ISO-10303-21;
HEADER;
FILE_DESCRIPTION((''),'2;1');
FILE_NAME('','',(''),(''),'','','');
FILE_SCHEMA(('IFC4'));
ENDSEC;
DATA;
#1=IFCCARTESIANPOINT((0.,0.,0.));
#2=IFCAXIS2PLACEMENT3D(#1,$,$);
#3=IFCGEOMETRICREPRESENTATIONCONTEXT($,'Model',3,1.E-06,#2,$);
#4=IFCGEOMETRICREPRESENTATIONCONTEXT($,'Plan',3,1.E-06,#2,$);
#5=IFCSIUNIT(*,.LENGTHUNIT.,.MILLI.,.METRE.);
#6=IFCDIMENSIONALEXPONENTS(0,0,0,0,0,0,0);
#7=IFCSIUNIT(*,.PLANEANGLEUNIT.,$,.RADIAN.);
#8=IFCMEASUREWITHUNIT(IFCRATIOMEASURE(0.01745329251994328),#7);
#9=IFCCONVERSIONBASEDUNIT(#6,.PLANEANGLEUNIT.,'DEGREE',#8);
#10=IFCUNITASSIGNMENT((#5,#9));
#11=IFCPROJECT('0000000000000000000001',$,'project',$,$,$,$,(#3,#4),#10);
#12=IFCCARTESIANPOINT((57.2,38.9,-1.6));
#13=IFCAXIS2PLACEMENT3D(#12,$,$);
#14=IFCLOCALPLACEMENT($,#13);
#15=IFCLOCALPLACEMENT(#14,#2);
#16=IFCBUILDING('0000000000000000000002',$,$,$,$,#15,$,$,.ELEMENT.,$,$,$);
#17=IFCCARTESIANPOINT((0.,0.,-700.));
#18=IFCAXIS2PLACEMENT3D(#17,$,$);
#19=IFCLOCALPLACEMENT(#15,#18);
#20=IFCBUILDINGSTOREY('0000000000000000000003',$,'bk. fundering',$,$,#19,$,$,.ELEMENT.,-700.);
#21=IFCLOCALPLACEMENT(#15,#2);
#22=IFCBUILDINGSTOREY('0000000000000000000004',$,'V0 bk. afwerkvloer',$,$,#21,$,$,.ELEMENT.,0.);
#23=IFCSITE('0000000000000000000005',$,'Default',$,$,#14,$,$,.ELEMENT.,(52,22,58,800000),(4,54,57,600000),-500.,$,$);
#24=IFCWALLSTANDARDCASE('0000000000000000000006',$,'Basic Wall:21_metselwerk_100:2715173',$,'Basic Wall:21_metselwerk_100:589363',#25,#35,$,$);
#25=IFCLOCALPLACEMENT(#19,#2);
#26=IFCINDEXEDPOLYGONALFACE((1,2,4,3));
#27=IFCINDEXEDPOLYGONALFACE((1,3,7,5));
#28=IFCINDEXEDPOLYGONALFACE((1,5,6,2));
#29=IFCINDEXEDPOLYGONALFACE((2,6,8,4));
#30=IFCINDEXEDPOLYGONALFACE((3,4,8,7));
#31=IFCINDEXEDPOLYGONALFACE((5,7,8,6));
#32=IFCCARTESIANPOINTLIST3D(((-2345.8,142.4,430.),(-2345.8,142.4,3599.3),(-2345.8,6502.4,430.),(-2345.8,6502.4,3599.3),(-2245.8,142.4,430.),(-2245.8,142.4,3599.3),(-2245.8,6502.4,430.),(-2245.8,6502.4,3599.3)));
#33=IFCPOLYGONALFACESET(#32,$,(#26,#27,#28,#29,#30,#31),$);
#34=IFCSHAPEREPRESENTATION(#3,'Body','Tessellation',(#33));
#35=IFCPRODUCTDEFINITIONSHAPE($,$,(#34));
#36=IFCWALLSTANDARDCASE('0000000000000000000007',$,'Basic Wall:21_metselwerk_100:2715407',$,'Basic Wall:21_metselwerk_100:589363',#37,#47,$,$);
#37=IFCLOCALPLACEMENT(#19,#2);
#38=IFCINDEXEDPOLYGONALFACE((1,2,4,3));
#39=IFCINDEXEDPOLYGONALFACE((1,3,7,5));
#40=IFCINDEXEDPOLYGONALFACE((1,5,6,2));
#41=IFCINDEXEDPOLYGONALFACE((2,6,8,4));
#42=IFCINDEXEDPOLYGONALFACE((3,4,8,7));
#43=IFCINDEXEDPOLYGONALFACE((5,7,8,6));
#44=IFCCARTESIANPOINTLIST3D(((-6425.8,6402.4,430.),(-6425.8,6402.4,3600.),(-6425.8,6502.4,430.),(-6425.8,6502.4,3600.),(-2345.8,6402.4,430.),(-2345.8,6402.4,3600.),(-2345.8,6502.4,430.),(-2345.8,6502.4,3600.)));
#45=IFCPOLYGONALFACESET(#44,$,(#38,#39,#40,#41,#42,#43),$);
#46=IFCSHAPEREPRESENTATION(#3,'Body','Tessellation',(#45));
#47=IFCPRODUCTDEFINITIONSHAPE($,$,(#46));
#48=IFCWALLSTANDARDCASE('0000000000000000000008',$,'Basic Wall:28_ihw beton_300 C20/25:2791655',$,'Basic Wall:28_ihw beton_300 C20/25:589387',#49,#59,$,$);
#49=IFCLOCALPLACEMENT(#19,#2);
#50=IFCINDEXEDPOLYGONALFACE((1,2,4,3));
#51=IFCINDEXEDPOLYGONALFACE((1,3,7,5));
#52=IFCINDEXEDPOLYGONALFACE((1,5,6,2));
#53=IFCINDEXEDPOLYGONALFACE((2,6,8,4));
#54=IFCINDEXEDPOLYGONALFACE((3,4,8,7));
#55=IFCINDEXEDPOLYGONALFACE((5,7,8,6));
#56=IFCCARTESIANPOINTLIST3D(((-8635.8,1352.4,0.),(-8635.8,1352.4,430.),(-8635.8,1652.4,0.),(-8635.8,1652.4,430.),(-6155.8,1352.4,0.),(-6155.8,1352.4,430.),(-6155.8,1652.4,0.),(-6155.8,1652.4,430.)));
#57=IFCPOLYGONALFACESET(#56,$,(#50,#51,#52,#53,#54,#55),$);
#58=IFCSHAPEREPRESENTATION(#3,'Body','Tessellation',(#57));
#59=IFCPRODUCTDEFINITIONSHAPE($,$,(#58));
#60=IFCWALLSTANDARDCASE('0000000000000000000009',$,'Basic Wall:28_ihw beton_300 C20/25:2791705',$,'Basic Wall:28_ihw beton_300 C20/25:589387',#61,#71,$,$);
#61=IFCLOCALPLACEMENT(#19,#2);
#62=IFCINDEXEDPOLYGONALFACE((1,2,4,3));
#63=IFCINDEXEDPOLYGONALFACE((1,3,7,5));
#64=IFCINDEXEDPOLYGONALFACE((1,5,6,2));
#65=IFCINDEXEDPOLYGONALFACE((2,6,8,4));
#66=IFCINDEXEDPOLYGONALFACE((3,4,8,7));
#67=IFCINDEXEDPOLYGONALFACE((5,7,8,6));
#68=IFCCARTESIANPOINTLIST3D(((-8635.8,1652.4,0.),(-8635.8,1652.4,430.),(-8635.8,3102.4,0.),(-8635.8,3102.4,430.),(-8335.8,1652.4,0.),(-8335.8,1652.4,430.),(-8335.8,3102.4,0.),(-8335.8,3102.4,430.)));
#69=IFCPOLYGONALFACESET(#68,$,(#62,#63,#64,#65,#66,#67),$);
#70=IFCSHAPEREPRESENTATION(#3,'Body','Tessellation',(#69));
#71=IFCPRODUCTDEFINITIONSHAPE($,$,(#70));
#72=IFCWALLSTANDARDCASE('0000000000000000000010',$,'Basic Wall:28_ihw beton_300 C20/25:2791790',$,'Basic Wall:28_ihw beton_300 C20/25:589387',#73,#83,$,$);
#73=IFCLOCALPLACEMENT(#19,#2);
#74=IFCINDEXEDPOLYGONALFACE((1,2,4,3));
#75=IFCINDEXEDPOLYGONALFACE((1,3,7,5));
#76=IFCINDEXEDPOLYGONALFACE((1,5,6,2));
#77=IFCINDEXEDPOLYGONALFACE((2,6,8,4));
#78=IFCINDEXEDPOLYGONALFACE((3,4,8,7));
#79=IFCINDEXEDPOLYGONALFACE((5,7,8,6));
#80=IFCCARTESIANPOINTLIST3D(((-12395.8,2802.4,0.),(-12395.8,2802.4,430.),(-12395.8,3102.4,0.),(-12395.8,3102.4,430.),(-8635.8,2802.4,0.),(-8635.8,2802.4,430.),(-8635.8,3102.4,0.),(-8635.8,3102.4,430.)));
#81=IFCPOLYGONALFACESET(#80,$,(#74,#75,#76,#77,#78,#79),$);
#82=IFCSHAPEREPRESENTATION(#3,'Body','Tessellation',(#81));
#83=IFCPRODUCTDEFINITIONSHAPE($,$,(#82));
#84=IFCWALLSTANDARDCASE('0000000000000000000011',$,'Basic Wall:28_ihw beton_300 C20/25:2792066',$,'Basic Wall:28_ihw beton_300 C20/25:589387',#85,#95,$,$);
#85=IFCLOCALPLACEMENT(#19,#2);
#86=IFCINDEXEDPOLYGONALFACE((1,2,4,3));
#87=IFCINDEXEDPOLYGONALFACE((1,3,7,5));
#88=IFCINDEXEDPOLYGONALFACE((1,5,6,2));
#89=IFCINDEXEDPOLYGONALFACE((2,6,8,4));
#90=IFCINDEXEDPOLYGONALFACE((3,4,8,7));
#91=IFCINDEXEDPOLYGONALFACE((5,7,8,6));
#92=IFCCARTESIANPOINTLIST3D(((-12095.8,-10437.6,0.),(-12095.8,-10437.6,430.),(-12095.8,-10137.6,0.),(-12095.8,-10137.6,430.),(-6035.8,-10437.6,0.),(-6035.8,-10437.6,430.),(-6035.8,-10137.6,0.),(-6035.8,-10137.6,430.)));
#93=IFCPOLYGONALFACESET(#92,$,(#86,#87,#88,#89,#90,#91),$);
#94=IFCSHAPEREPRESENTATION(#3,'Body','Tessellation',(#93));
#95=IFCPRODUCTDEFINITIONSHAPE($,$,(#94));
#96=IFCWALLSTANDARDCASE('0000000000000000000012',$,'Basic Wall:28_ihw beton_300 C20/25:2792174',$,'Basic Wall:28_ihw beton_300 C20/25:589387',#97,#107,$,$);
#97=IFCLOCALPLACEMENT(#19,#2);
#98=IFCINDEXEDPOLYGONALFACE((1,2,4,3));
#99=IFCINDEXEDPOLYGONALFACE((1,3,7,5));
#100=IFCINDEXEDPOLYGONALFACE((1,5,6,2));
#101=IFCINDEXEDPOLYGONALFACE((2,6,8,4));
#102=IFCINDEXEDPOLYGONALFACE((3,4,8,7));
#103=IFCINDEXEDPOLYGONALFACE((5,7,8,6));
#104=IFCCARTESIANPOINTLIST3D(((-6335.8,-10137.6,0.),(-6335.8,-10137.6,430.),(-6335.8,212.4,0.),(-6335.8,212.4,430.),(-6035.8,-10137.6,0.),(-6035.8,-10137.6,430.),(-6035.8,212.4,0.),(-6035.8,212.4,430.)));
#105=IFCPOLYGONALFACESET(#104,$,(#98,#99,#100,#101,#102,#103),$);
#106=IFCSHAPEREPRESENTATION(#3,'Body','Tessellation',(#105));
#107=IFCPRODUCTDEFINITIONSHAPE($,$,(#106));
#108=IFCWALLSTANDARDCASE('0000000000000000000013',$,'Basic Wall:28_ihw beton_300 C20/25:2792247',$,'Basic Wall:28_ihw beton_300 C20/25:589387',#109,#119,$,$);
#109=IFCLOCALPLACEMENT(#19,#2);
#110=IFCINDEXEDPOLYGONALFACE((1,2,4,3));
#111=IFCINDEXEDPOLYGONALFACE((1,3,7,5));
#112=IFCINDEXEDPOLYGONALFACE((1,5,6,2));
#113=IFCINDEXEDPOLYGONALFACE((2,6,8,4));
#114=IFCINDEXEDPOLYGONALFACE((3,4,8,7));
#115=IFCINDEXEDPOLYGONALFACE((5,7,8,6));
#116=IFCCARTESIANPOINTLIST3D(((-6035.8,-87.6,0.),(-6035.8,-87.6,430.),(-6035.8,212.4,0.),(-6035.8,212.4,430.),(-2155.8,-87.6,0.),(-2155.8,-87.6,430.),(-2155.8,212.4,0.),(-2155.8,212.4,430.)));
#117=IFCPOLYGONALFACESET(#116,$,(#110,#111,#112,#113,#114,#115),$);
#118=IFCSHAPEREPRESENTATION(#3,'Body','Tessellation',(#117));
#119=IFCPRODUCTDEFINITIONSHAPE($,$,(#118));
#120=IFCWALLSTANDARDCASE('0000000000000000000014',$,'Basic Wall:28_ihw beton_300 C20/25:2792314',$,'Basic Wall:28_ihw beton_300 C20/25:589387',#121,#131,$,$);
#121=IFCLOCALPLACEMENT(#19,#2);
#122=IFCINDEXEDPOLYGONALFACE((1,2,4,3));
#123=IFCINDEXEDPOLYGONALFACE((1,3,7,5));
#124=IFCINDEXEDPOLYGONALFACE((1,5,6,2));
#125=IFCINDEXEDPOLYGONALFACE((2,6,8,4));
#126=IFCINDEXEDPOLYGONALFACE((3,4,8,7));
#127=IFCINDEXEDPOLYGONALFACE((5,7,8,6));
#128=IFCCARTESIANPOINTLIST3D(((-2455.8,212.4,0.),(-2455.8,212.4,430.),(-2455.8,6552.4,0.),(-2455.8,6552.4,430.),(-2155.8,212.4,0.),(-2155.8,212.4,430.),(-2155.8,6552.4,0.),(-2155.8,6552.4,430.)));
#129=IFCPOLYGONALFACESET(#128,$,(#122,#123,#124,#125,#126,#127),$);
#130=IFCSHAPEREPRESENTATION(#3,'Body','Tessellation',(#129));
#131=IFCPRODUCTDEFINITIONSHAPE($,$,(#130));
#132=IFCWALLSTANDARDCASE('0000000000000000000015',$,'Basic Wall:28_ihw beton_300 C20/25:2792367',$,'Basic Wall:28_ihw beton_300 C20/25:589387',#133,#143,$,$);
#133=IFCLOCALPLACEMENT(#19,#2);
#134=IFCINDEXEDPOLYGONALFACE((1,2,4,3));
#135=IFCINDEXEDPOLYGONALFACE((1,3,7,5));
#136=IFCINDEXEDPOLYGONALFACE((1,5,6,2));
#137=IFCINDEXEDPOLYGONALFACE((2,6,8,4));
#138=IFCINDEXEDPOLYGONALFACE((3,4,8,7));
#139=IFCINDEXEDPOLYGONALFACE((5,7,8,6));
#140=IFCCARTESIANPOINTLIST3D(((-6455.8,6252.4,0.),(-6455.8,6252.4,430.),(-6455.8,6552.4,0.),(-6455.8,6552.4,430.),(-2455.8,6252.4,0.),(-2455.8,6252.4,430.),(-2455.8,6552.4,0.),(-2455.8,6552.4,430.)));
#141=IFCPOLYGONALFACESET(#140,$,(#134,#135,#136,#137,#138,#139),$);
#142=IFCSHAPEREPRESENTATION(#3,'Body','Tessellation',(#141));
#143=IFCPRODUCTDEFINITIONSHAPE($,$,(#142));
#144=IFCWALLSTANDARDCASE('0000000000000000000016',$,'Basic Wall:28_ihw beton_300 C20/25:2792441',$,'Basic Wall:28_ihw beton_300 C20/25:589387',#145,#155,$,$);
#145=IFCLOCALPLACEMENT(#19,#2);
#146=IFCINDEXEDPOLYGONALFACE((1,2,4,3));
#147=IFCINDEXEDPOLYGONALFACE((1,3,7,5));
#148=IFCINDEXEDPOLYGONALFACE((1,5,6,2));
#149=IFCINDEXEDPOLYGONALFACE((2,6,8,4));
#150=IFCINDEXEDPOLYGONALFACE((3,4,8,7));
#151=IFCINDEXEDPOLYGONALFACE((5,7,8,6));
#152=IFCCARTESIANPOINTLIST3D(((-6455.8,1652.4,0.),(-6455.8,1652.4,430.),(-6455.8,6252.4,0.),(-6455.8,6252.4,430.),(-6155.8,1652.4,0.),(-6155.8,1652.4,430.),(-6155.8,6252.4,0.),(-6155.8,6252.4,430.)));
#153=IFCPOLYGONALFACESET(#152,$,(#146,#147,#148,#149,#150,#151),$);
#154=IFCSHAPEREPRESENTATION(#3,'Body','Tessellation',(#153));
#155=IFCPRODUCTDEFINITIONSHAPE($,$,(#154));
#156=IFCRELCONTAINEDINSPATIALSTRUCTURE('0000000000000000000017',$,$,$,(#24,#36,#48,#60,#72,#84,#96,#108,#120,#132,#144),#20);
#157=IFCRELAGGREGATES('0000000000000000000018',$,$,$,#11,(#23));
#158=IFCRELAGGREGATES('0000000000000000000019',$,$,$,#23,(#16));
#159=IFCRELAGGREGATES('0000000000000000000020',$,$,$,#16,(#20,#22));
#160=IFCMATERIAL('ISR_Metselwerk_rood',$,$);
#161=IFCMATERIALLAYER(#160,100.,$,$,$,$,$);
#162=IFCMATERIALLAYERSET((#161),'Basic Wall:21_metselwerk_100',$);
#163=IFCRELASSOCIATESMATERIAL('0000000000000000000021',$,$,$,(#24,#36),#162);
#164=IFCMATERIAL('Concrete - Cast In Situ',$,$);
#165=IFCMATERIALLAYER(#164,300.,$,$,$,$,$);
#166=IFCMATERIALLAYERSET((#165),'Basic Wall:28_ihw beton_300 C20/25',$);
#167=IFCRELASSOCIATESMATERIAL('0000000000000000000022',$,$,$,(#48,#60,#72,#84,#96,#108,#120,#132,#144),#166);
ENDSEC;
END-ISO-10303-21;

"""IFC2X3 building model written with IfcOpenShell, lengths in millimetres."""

from ifc_helpers import new_model, entity, si_unit, converted_unit, frame, frame_2d, origin, place, context, project, spatial, rectangle, extrude, material, layer, layer_set, layer_usage, element, save


model = new_model("IFC2X3")

# Units and contexts
model_context = context("Model", 3, precision=1e-06, world=origin())
plan_context = context("Plan", 3, precision=1e-06, world=origin())
ifc_project = project(units=[si_unit("LENGTHUNIT", "METRE", prefix="MILLI"), converted_unit("PLANEANGLEUNIT", "DEGREE", entity("IfcRatioMeasure", 0.01745329251994328), si_unit("PLANEANGLEUNIT", "RADIAN"), dimensions=[0, 0, 0, 0, 0, 0, 0])], contexts=[model_context, plan_context])

# Site, building, storey
site_placement = place(None, frame((57.2, 38.9, -1.6)))
site = spatial("IfcSite", under=ifc_project, at=site_placement, Name="Default", CompositionType="ELEMENT", RefLatitude=(52, 22, 58, 800000), RefLongitude=(4, 54, 57, 600000), RefElevation=-500.0)
building_placement = place(site_placement, origin())
building = spatial("IfcBuilding", under=site, at=building_placement, CompositionType="ELEMENT")
storey_1_placement = place(building_placement, frame((0.0, 0.0, -700.0)))
storey_1 = spatial("IfcBuildingStorey", under=building, at=storey_1_placement, Name="bk. fundering", CompositionType="ELEMENT", Elevation=-700.0)

# Shared definitions
ifc_material_1 = material(Name="ISR_Metselwerk_rood")
ifc_layer_1 = layer(ifc_material_1, 100.0)
ifc_layer_set_1 = layer_set([ifc_layer_1], Name="Basic Wall:21_metselwerk_100")

# Walls
ifc_layer_usage_1 = layer_usage(ifc_layer_set_1, "AXIS2", "NEGATIVE", 50.0)
wall_1_placement = place(storey_1_placement, frame((-2295.8, 142.4, 430.0), z_axis=(0.0, 0.0, 1.0), x_axis=(0.0, 1.0, 0.0)))
element("IfcWallStandardCase", 1, at=wall_1_placement, inside=storey_1, material=ifc_layer_usage_1, Name="Basic Wall:21_metselwerk_100:2715173", ObjectType="Basic Wall:21_metselwerk_100:589363", context=model_context, shape_type="SweptSolid", body=[
    extrude(rectangle(XDim=6360.0, YDim=100.0, at=frame_2d((3180.0, 0.0), x_axis=(-1.0, 0.0))), origin(), (0.0, 0.0, 1.0), 3169.3),
])
ifc_layer_usage_2 = layer_usage(ifc_layer_set_1, "AXIS2", "NEGATIVE", 50.0)
wall_2_placement = place(storey_1_placement, frame((-2345.8, 6452.4, 430.0), z_axis=(0.0, 0.0, 1.0), x_axis=(-1.0, 0.0, 0.0)))
element("IfcWallStandardCase", 2, at=wall_2_placement, inside=storey_1, material=ifc_layer_usage_2, Name="Basic Wall:21_metselwerk_100:2715407", ObjectType="Basic Wall:21_metselwerk_100:589363", context=model_context, shape_type="SweptSolid", body=[
    extrude(rectangle(XDim=4080.0, YDim=100.0, at=frame_2d((2040.0, 0.0), x_axis=(-1.0, 0.0))), origin(), (0.0, 0.0, 1.0), 3170.0),
])

# Shared definitions
storey_2_placement = place(building_placement, origin())
storey_2 = spatial("IfcBuildingStorey", under=building, at=storey_2_placement, Name="V0 bk. afwerkvloer", CompositionType="ELEMENT", Elevation=0.0)

# Walls
ifc_material_2 = material(Name="Concrete - Cast In Situ")
ifc_layer_2 = layer(ifc_material_2, 300.0)
ifc_layer_set_2 = layer_set([ifc_layer_2], Name="Basic Wall:28_ihw beton_300 C20/25")
ifc_layer_usage_3 = layer_usage(ifc_layer_set_2, "AXIS2", "NEGATIVE", 150.0)
wall_3_placement = place(storey_1_placement, frame((-6155.8, 1502.4, 0.0), z_axis=(0.0, 0.0, 1.0), x_axis=(-1.0, 0.0, 0.0)))
element("IfcWallStandardCase", 3, at=wall_3_placement, inside=storey_1, material=ifc_layer_usage_3, Name="Basic Wall:28_ihw beton_300 C20/25:2791655", ObjectType="Basic Wall:28_ihw beton_300 C20/25:589387", context=model_context, shape_type="SweptSolid", body=[
    extrude(rectangle(XDim=2480.0, YDim=300.0, at=frame_2d((1240.0, 0.0), x_axis=(-1.0, 0.0))), origin(), (0.0, 0.0, 1.0), 430.0),
])
ifc_layer_usage_4 = layer_usage(ifc_layer_set_2, "AXIS2", "NEGATIVE", 150.0)
wall_4_placement = place(storey_1_placement, frame((-8485.8, 1652.4, 0.0), z_axis=(0.0, 0.0, 1.0), x_axis=(0.0, 1.0, 0.0)))
element("IfcWallStandardCase", 4, at=wall_4_placement, inside=storey_1, material=ifc_layer_usage_4, Name="Basic Wall:28_ihw beton_300 C20/25:2791705", ObjectType="Basic Wall:28_ihw beton_300 C20/25:589387", context=model_context, shape_type="SweptSolid", body=[
    extrude(rectangle(XDim=1450.0, YDim=300.0, at=frame_2d((725.0, 0.0), x_axis=(-1.0, 0.0))), origin(), (0.0, 0.0, 1.0), 430.0),
])
ifc_layer_usage_5 = layer_usage(ifc_layer_set_2, "AXIS2", "NEGATIVE", 150.0)
wall_5_placement = place(storey_1_placement, frame((-8635.8, 2952.4, 0.0), z_axis=(0.0, 0.0, 1.0), x_axis=(-1.0, 0.0, 0.0)))
element("IfcWallStandardCase", 5, at=wall_5_placement, inside=storey_1, material=ifc_layer_usage_5, Name="Basic Wall:28_ihw beton_300 C20/25:2791790", ObjectType="Basic Wall:28_ihw beton_300 C20/25:589387", context=model_context, shape_type="SweptSolid", body=[
    extrude(rectangle(XDim=3760.0, YDim=300.0, at=frame_2d((1880.0, 0.0), x_axis=(-1.0, 0.0))), origin(), (0.0, 0.0, 1.0), 430.0),
])
ifc_layer_usage_6 = layer_usage(ifc_layer_set_2, "AXIS2", "NEGATIVE", 150.0)
wall_6_placement = place(storey_1_placement, frame((-12095.8, -10287.6, 0.0)))
element("IfcWallStandardCase", 6, at=wall_6_placement, inside=storey_1, material=ifc_layer_usage_6, Name="Basic Wall:28_ihw beton_300 C20/25:2792066", ObjectType="Basic Wall:28_ihw beton_300 C20/25:589387", context=model_context, shape_type="SweptSolid", body=[
    extrude(rectangle(XDim=6060.0, YDim=300.0, at=frame_2d((3030.0, 0.0), x_axis=(-1.0, 0.0))), origin(), (0.0, 0.0, 1.0), 430.0),
])
ifc_layer_usage_7 = layer_usage(ifc_layer_set_2, "AXIS2", "NEGATIVE", 150.0)
wall_7_placement = place(storey_1_placement, frame((-6185.8, -10137.6, 0.0), z_axis=(0.0, 0.0, 1.0), x_axis=(0.0, 1.0, 0.0)))
element("IfcWallStandardCase", 7, at=wall_7_placement, inside=storey_1, material=ifc_layer_usage_7, Name="Basic Wall:28_ihw beton_300 C20/25:2792174", ObjectType="Basic Wall:28_ihw beton_300 C20/25:589387", context=model_context, shape_type="SweptSolid", body=[
    extrude(rectangle(XDim=10350.0, YDim=300.0, at=frame_2d((5175.0, 0.0), x_axis=(-1.0, 0.0))), origin(), (0.0, 0.0, 1.0), 430.0),
])
ifc_layer_usage_8 = layer_usage(ifc_layer_set_2, "AXIS2", "NEGATIVE", 150.0)
wall_8_placement = place(storey_1_placement, frame((-6035.8, 62.4, 0.0)))
element("IfcWallStandardCase", 8, at=wall_8_placement, inside=storey_1, material=ifc_layer_usage_8, Name="Basic Wall:28_ihw beton_300 C20/25:2792247", ObjectType="Basic Wall:28_ihw beton_300 C20/25:589387", context=model_context, shape_type="SweptSolid", body=[
    extrude(rectangle(XDim=3880.0, YDim=300.0, at=frame_2d((1940.0, 0.0), x_axis=(-1.0, 0.0))), origin(), (0.0, 0.0, 1.0), 430.0),
])
ifc_layer_usage_9 = layer_usage(ifc_layer_set_2, "AXIS2", "NEGATIVE", 150.0)
wall_9_placement = place(storey_1_placement, frame((-2305.8, 212.4, 0.0), z_axis=(0.0, 0.0, 1.0), x_axis=(0.0, 1.0, 0.0)))
element("IfcWallStandardCase", 9, at=wall_9_placement, inside=storey_1, material=ifc_layer_usage_9, Name="Basic Wall:28_ihw beton_300 C20/25:2792314", ObjectType="Basic Wall:28_ihw beton_300 C20/25:589387", context=model_context, shape_type="SweptSolid", body=[
    extrude(rectangle(XDim=6340.0, YDim=300.0, at=frame_2d((3170.0, 0.0), x_axis=(-1.0, 0.0))), origin(), (0.0, 0.0, 1.0), 430.0),
])
ifc_layer_usage_10 = layer_usage(ifc_layer_set_2, "AXIS2", "NEGATIVE", 150.0)
wall_10_placement = place(storey_1_placement, frame((-2455.8, 6402.4, 0.0), z_axis=(0.0, 0.0, 1.0), x_axis=(-1.0, 0.0, 0.0)))
element("IfcWallStandardCase", 10, at=wall_10_placement, inside=storey_1, material=ifc_layer_usage_10, Name="Basic Wall:28_ihw beton_300 C20/25:2792367", ObjectType="Basic Wall:28_ihw beton_300 C20/25:589387", context=model_context, shape_type="SweptSolid", body=[
    extrude(rectangle(XDim=4000.0, YDim=300.0, at=frame_2d((2000.0, 0.0), x_axis=(-1.0, 0.0))), origin(), (0.0, 0.0, 1.0), 430.0),
])
ifc_layer_usage_11 = layer_usage(ifc_layer_set_2, "AXIS2", "NEGATIVE", 150.0)
wall_11_placement = place(storey_1_placement, frame((-6305.8, 6252.4, 0.0), z_axis=(0.0, 0.0, 1.0), x_axis=(0.0, -1.0, 0.0)))
element("IfcWallStandardCase", 11, at=wall_11_placement, inside=storey_1, material=ifc_layer_usage_11, Name="Basic Wall:28_ihw beton_300 C20/25:2792441", ObjectType="Basic Wall:28_ihw beton_300 C20/25:589387", context=model_context, shape_type="SweptSolid", body=[
    extrude(rectangle(XDim=4600.0, YDim=300.0, at=frame_2d((2300.0, 0.0), x_axis=(-1.0, 0.0))), origin(), (0.0, 0.0, 1.0), 430.0),
])

save(model, "model.ifc")
